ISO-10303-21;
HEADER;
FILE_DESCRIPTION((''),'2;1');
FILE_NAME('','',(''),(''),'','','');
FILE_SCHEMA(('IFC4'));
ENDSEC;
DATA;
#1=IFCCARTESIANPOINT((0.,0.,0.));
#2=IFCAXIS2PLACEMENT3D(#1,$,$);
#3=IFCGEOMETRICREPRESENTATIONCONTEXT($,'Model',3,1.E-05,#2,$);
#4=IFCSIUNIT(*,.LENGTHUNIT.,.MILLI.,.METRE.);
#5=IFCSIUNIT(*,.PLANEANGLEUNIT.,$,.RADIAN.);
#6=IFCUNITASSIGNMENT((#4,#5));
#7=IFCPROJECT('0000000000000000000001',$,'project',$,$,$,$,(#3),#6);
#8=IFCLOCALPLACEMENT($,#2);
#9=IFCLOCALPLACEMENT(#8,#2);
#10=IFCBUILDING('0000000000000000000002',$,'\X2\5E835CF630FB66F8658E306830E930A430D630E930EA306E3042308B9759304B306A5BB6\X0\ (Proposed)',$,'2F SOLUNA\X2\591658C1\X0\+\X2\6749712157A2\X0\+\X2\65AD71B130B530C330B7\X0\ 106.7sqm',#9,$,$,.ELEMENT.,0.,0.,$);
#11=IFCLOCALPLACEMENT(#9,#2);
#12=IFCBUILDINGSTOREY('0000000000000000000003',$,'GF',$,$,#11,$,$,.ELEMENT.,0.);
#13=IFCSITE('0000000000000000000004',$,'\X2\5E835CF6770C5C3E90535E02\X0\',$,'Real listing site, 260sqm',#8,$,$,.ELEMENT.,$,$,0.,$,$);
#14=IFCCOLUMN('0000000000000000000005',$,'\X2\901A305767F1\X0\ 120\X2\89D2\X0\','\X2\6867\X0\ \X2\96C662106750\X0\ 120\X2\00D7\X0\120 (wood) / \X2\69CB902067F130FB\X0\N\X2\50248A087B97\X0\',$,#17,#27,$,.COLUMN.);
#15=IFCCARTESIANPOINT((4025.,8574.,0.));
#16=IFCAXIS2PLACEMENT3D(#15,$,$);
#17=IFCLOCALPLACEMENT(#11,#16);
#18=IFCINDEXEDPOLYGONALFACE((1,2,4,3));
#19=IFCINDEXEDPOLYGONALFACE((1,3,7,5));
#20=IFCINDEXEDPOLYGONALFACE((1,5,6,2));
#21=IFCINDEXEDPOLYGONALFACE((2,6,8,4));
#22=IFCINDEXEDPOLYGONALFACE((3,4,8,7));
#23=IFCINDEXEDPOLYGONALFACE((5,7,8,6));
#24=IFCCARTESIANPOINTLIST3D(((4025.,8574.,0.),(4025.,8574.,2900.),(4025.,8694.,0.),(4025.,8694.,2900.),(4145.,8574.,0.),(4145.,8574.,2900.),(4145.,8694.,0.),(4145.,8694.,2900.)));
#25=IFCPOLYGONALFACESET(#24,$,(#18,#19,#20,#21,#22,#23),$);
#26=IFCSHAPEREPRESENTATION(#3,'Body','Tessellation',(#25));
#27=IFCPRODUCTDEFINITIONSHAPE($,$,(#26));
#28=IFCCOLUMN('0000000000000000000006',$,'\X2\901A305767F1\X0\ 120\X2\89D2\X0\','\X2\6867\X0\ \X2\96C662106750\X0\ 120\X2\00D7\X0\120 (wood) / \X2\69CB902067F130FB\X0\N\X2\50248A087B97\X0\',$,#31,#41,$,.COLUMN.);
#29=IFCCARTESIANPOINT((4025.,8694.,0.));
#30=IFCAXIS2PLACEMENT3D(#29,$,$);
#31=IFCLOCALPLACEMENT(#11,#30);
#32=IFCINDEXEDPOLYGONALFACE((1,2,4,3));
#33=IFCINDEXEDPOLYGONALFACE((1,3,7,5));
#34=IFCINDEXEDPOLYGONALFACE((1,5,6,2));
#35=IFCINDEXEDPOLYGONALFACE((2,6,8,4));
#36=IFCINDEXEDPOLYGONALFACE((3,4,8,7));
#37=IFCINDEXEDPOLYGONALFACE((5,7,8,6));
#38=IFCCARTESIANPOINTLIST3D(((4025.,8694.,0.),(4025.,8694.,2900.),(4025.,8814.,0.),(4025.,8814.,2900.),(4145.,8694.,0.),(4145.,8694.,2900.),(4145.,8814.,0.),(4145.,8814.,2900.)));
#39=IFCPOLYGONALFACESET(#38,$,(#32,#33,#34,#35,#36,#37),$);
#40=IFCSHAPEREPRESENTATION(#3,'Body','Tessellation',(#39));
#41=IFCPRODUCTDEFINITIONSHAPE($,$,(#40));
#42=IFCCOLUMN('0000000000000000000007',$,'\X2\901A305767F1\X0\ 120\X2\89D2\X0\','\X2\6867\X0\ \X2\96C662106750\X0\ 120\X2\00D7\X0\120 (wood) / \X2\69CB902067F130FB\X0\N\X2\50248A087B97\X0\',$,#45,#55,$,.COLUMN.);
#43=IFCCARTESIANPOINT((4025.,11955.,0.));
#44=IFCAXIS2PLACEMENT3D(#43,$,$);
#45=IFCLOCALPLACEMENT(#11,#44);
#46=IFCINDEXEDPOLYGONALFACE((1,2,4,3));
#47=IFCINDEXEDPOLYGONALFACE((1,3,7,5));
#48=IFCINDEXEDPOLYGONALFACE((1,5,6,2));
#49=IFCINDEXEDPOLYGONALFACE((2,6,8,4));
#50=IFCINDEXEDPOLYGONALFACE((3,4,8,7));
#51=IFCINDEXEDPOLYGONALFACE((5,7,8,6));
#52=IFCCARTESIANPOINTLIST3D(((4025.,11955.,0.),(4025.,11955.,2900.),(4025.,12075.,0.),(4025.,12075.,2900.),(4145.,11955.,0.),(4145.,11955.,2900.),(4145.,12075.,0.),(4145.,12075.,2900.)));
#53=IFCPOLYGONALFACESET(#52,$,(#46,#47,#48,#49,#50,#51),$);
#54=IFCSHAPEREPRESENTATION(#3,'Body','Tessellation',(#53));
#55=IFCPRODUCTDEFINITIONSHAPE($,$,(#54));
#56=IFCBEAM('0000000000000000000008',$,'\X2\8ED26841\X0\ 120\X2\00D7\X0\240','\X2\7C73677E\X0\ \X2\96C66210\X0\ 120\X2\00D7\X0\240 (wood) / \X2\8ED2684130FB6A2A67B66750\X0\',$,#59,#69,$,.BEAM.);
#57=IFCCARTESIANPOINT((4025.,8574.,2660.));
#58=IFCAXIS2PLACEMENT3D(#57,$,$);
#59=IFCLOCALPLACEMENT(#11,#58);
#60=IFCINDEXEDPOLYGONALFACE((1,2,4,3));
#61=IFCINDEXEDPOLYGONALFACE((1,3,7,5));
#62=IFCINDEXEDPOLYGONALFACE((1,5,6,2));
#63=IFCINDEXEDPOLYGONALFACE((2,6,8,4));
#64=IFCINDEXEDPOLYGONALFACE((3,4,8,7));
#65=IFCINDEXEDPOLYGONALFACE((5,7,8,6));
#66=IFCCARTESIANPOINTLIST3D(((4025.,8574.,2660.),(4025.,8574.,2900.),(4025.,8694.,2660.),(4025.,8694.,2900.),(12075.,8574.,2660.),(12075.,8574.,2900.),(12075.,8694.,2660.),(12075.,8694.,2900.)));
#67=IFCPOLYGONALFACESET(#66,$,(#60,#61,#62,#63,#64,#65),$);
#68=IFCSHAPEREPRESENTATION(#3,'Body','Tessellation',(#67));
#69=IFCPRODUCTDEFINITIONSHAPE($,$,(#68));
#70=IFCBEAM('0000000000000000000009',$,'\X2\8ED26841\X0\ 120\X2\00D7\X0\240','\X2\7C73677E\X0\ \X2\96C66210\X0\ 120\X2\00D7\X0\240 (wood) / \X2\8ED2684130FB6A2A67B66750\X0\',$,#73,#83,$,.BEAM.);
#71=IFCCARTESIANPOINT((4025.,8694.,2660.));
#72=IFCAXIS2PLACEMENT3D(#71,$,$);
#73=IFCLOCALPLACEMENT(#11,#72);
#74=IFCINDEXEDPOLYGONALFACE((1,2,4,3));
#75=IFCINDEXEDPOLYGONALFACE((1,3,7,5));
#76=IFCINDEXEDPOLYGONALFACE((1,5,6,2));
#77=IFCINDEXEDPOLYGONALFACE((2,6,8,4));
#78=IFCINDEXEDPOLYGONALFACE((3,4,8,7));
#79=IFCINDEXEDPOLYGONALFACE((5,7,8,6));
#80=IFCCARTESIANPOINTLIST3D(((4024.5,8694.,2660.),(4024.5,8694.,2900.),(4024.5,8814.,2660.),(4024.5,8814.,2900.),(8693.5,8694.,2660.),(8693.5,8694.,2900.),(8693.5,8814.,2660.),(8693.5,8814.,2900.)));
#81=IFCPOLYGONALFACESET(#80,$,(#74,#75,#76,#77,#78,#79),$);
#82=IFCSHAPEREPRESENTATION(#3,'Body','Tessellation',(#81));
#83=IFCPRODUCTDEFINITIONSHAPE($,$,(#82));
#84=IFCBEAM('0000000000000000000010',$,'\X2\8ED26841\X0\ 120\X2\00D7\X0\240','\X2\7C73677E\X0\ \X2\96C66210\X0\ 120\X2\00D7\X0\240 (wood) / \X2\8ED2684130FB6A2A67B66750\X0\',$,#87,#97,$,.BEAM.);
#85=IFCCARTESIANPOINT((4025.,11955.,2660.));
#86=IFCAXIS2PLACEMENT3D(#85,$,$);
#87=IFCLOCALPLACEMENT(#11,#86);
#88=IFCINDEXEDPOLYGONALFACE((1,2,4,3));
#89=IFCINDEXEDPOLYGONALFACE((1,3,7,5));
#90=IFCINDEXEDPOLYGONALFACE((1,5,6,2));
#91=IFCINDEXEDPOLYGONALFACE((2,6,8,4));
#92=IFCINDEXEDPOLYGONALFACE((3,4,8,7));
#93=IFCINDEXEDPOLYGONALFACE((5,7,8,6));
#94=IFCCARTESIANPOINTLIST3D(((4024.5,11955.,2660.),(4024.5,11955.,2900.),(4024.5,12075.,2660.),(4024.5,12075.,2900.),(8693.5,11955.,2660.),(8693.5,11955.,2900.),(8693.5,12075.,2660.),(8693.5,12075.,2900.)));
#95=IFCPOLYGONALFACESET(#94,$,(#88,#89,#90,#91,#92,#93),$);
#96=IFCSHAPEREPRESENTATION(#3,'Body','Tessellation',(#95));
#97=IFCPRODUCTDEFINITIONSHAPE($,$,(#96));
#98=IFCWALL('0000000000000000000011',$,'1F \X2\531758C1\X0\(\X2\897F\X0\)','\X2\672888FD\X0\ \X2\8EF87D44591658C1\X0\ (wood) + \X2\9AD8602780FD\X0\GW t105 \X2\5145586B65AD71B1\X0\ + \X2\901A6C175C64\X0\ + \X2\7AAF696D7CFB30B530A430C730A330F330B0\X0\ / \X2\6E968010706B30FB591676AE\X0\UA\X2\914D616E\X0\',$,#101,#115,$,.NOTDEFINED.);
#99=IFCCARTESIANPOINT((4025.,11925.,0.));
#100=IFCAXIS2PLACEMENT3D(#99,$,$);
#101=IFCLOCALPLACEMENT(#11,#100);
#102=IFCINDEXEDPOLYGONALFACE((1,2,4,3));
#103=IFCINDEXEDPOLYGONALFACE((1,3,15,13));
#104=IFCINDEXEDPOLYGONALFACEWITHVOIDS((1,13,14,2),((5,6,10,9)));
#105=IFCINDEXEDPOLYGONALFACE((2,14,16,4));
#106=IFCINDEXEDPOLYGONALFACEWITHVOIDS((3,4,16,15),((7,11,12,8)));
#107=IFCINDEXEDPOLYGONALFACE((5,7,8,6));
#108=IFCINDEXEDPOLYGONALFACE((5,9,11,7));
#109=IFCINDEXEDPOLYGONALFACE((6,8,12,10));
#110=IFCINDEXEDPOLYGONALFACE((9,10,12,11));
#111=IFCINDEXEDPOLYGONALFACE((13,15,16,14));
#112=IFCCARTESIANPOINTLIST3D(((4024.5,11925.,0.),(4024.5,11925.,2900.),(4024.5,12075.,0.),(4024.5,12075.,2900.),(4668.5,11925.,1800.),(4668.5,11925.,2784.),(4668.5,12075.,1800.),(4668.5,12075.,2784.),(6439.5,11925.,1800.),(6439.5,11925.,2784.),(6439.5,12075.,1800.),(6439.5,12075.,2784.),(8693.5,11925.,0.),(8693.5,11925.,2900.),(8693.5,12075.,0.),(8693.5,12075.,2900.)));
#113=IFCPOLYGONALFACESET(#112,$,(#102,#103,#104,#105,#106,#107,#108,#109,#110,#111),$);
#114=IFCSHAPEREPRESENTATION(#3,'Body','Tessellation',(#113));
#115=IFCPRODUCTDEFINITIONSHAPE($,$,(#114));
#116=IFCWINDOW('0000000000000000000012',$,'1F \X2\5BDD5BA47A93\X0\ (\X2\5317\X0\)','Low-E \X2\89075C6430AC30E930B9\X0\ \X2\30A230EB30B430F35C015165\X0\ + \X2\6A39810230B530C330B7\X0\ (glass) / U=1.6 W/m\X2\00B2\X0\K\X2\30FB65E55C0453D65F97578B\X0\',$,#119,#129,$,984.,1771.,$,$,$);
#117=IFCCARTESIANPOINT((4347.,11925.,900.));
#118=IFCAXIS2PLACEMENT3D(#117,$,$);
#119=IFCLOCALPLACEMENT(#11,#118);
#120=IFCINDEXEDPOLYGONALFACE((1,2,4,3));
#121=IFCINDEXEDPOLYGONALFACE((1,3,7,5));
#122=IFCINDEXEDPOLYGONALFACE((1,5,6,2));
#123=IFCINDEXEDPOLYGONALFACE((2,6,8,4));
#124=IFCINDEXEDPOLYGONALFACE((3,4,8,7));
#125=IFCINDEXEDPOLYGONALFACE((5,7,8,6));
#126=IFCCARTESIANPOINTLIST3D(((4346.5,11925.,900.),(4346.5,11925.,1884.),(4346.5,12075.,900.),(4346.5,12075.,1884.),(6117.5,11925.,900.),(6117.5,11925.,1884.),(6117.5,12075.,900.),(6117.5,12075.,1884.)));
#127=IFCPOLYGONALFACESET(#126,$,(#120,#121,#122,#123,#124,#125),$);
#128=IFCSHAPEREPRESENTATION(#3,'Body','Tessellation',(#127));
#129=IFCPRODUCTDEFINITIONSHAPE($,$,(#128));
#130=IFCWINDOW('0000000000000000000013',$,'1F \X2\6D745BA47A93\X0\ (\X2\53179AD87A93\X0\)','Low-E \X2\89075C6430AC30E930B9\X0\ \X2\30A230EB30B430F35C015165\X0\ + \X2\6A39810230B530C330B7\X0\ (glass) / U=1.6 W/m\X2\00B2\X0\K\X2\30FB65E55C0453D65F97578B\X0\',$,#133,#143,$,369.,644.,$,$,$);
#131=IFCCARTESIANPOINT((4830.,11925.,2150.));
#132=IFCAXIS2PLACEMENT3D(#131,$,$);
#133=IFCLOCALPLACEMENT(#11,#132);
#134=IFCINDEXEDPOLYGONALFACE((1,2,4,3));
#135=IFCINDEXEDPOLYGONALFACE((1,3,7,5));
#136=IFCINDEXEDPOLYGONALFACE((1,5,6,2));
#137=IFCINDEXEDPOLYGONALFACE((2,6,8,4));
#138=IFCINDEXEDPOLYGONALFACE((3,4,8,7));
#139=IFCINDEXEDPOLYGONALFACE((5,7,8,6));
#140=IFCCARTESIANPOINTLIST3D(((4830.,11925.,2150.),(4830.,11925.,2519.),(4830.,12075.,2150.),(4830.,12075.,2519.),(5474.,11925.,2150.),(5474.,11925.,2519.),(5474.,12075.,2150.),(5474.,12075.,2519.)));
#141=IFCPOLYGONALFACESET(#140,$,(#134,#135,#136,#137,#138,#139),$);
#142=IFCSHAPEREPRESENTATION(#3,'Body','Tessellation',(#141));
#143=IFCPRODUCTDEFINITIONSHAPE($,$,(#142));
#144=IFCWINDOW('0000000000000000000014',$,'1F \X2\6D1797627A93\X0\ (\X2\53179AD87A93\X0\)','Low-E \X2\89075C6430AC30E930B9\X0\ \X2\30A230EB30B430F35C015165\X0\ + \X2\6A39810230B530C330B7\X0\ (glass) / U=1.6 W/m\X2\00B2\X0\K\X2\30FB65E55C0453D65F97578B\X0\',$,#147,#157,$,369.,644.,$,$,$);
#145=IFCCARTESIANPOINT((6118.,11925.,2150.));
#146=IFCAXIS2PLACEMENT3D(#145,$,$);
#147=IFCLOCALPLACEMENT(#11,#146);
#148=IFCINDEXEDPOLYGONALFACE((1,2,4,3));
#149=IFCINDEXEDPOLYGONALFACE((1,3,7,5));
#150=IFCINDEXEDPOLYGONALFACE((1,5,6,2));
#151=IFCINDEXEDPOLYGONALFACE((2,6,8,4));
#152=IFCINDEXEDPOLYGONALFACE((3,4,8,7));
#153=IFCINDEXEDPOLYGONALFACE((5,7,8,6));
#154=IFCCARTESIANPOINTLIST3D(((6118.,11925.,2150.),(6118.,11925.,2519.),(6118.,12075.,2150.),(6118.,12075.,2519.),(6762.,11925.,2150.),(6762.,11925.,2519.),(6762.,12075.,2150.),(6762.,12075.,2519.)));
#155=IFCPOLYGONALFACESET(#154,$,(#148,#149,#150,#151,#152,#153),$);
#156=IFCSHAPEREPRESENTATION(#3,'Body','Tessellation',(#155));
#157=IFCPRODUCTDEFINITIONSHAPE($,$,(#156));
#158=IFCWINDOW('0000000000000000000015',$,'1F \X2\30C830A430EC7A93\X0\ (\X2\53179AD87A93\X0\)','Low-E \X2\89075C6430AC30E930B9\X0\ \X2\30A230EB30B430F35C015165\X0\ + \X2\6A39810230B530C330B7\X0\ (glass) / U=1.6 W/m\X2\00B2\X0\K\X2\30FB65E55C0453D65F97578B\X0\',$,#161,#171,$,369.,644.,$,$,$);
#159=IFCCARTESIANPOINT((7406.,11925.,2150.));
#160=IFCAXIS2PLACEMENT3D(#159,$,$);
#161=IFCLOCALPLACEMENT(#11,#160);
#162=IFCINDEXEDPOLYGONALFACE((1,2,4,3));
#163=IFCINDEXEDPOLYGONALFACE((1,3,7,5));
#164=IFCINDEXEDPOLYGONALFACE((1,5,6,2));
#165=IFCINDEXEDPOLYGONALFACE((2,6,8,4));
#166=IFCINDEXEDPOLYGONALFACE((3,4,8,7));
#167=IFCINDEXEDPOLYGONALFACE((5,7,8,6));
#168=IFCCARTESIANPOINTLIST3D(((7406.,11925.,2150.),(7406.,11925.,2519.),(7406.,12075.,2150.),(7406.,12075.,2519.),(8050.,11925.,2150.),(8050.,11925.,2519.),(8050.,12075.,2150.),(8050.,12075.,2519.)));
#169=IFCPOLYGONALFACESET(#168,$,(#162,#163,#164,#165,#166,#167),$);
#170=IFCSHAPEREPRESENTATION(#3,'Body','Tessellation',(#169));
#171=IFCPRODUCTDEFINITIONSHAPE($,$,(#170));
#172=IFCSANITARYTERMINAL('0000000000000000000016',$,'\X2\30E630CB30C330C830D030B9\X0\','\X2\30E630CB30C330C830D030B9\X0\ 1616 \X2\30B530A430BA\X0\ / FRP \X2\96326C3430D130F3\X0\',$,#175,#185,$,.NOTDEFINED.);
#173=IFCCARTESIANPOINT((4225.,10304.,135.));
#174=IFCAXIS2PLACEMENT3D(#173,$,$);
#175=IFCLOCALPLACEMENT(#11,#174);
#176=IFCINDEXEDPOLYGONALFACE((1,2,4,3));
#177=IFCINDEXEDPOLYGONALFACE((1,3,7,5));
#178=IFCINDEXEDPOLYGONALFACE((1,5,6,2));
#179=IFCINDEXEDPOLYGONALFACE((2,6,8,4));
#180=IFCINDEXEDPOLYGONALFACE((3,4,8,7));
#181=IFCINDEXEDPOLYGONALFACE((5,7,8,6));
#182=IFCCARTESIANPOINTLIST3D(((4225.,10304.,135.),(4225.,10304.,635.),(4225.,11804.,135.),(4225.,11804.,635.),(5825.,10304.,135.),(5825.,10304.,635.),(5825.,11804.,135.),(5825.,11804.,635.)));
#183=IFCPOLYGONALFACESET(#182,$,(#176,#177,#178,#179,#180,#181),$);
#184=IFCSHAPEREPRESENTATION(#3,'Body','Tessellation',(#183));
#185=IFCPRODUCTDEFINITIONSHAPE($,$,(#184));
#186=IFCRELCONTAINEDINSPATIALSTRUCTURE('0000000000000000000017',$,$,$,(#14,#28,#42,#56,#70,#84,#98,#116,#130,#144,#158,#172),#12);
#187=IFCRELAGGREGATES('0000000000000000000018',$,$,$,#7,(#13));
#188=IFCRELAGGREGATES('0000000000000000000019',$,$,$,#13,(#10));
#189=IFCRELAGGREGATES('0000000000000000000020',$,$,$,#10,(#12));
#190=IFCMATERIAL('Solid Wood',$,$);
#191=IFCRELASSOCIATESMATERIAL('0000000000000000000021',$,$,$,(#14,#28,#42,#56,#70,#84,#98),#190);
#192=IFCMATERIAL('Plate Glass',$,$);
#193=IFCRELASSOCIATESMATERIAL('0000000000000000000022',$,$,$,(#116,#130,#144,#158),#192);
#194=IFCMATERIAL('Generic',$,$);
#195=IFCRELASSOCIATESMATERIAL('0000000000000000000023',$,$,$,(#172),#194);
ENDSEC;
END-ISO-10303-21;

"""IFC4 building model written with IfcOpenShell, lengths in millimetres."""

from ifc_helpers import new_model, si_unit, frame, frame_2d, origin, place, context, project, spatial, rectangle, extrude, material, element, fill, save


model = new_model("IFC4")

# Units and contexts
model_context = context("Model", 3, precision=1e-05, world=origin())
ifc_project = project(units=[si_unit("LENGTHUNIT", "METRE", prefix="MILLI"), si_unit("PLANEANGLEUNIT", "RADIAN")], contexts=[model_context])

# Site, building, storey
site_placement = place(None, origin())
site = spatial("IfcSite", under=ifc_project, at=site_placement, Name="広島県尾道市", ObjectType="Real listing site, 260sqm", CompositionType="ELEMENT", RefElevation=0.0)
building_placement = place(site_placement, origin())
building = spatial("IfcBuilding", under=site, at=building_placement, Name="広島・書斎とライブラリのある静かな家 (Proposed)", ObjectType="2F SOLUNA外壁+杉無垢+断熱サッシ 106.7sqm", CompositionType="ELEMENT", ElevationOfRefHeight=0.0, ElevationOfTerrain=0.0)
storey_placement = place(building_placement, origin())
storey = spatial("IfcBuildingStorey", under=building, at=storey_placement, Name="GF", CompositionType="ELEMENT", Elevation=0.0)

# Columns
ifc_material_1 = material(Name="Solid Wood")
column_1_placement = place(storey_placement, frame((4025.0, 8574.0, 0.0)))
element("IfcColumn", 1, at=column_1_placement, inside=storey, material=ifc_material_1, Name="通し柱 120角", Description="桧 集成材 120×120 (wood) / 構造柱・N値計算", PredefinedType="COLUMN", context=model_context, shape_type="SweptSolid", body=[
    extrude(rectangle(XDim=120.0, YDim=120.0, at=frame_2d((60.0, 60.0))), frame((4025.0, 8574.0, 0.0)), (0.0, 0.0, 1.0), 2900.0),
])
column_2_placement = place(storey_placement, frame((4025.0, 8694.0, 0.0)))
element("IfcColumn", 2, at=column_2_placement, inside=storey, material=ifc_material_1, Name="通し柱 120角", Description="桧 集成材 120×120 (wood) / 構造柱・N値計算", PredefinedType="COLUMN", context=model_context, shape_type="SweptSolid", body=[
    extrude(rectangle(XDim=120.0, YDim=120.0, at=frame_2d((60.0, 60.0))), frame((4025.0, 8694.0, 0.0)), (0.0, 0.0, 1.0), 2900.0),
])
column_3_placement = place(storey_placement, frame((4025.0, 11955.0, 0.0)))
element("IfcColumn", 3, at=column_3_placement, inside=storey, material=ifc_material_1, Name="通し柱 120角", Description="桧 集成材 120×120 (wood) / 構造柱・N値計算", PredefinedType="COLUMN", context=model_context, shape_type="SweptSolid", body=[
    extrude(rectangle(XDim=120.0, YDim=120.0, at=frame_2d((60.0, 60.0))), frame((4025.0, 11955.0, 0.0)), (0.0, 0.0, 1.0), 2900.0),
])

# Beams
beam_1_placement = place(storey_placement, frame((4025.0, 8574.0, 2660.0)))
element("IfcBeam", 4, at=beam_1_placement, inside=storey, material=ifc_material_1, Name="軒桁 120×240", Description="米松 集成 120×240 (wood) / 軒桁・横架材", PredefinedType="BEAM", context=model_context, shape_type="SweptSolid", body=[
    extrude(rectangle(XDim=8050.0, YDim=120.0, at=frame_2d((4025.0, 60.0))), frame((4025.0, 8574.0, 2660.0)), (0.0, 0.0, 1.0), 240.0),
])
beam_2_placement = place(storey_placement, frame((4025.0, 8694.0, 2660.0)))
element("IfcBeam", 5, at=beam_2_placement, inside=storey, material=ifc_material_1, Name="軒桁 120×240", Description="米松 集成 120×240 (wood) / 軒桁・横架材", PredefinedType="BEAM", context=model_context, shape_type="SweptSolid", body=[
    extrude(rectangle(XDim=4669.0, YDim=120.0, at=frame_2d((2334.0, 60.0))), frame((4025.0, 8694.0, 2660.0)), (0.0, 0.0, 1.0), 240.0),
])
beam_3_placement = place(storey_placement, frame((4025.0, 11955.0, 2660.0)))
element("IfcBeam", 6, at=beam_3_placement, inside=storey, material=ifc_material_1, Name="軒桁 120×240", Description="米松 集成 120×240 (wood) / 軒桁・横架材", PredefinedType="BEAM", context=model_context, shape_type="SweptSolid", body=[
    extrude(rectangle(XDim=4669.0, YDim=120.0, at=frame_2d((2334.0, 60.0))), frame((4025.0, 11955.0, 2660.0)), (0.0, 0.0, 1.0), 240.0),
])

# Wall, openings, windows
wall_1_placement = place(storey_placement, frame((4025.0, 11925.0, 0.0)))
wall_1 = element("IfcWall", 7, at=wall_1_placement, inside=storey, material=ifc_material_1, Name="1F 北壁(西)", Description="木製 軸組外壁 (wood) + 高性能GW t105 充填断熱 + 通気層 + 窯業系サイディング / 準耐火・外皮UA配慮", PredefinedType="NOTDEFINED", context=model_context, shape_type="SweptSolid", body=[
    extrude(rectangle(XDim=4669.0, YDim=150.0, at=frame_2d((2334.0, 75.0))), frame((4025.0, 11925.0, 0.0)), (0.0, 0.0, 1.0), 2900.0),
])
opening_1_placement = place(storey_placement, frame((4347.0, 11925.0, 900.0)))
opening_1 = element("IfcOpeningElement", 8, at=opening_1_placement, cuts=wall_1, PredefinedType="NOTDEFINED", context=model_context, shape_type="SweptSolid", body=[
    extrude(rectangle(XDim=1771.0, YDim=150.0, at=frame_2d((885.0, 75.0))), frame((4347.0, 11925.0, 900.0)), (0.0, 0.0, 1.0), 984.0),
])
opening_2_placement = place(storey_placement, frame((4830.0, 11925.0, 2150.0)))
opening_2 = element("IfcOpeningElement", 9, at=opening_2_placement, cuts=wall_1, PredefinedType="NOTDEFINED", context=model_context, shape_type="SweptSolid", body=[
    extrude(rectangle(XDim=644.0, YDim=150.0, at=frame_2d((322.0, 75.0))), frame((4830.0, 11925.0, 2150.0)), (0.0, 0.0, 1.0), 369.0),
])
opening_3_placement = place(storey_placement, frame((6118.0, 11925.0, 2150.0)))
opening_3 = element("IfcOpeningElement", 10, at=opening_3_placement, cuts=wall_1, PredefinedType="NOTDEFINED", context=model_context, shape_type="SweptSolid", body=[
    extrude(rectangle(XDim=644.0, YDim=150.0, at=frame_2d((322.0, 75.0))), frame((6118.0, 11925.0, 2150.0)), (0.0, 0.0, 1.0), 369.0),
])
opening_4_placement = place(storey_placement, frame((7406.0, 11925.0, 2150.0)))
opening_4 = element("IfcOpeningElement", 11, at=opening_4_placement, cuts=wall_1, PredefinedType="NOTDEFINED", context=model_context, shape_type="SweptSolid", body=[
    extrude(rectangle(XDim=644.0, YDim=150.0, at=frame_2d((322.0, 75.0))), frame((7406.0, 11925.0, 2150.0)), (0.0, 0.0, 1.0), 369.0),
])
ifc_material_2 = material(Name="Plate Glass")
window_1_placement = place(storey_placement, frame((4347.0, 11925.0, 900.0)))
window_1 = element("IfcWindow", 12, at=window_1_placement, inside=storey, material=ifc_material_2, Name="1F 寝室窓 (北)", Description="Low-E 複層ガラス アルゴン封入 + 樹脂サッシ (glass) / U=1.6 W/m²K・日射取得型", OverallHeight=984.0, OverallWidth=1771.0, context=model_context, shape_type="SweptSolid", body=[
    extrude(rectangle(XDim=1771.0, YDim=150.0, at=frame_2d((885.0, 75.0))), frame((4347.0, 11925.0, 900.0)), (0.0, 0.0, 1.0), 984.0),
])
fill(opening_1, window_1)
window_2_placement = place(storey_placement, frame((4830.0, 11925.0, 2150.0)))
window_2 = element("IfcWindow", 13, at=window_2_placement, inside=storey, material=ifc_material_2, Name="1F 浴室窓 (北高窓)", Description="Low-E 複層ガラス アルゴン封入 + 樹脂サッシ (glass) / U=1.6 W/m²K・日射取得型", OverallHeight=369.0, OverallWidth=644.0, context=model_context, shape_type="SweptSolid", body=[
    extrude(rectangle(XDim=644.0, YDim=150.0, at=frame_2d((322.0, 75.0))), frame((4830.0, 11925.0, 2150.0)), (0.0, 0.0, 1.0), 369.0),
])
fill(opening_2, window_2)
window_3_placement = place(storey_placement, frame((6118.0, 11925.0, 2150.0)))
window_3 = element("IfcWindow", 14, at=window_3_placement, inside=storey, material=ifc_material_2, Name="1F 洗面窓 (北高窓)", Description="Low-E 複層ガラス アルゴン封入 + 樹脂サッシ (glass) / U=1.6 W/m²K・日射取得型", OverallHeight=369.0, OverallWidth=644.0, context=model_context, shape_type="SweptSolid", body=[
    extrude(rectangle(XDim=644.0, YDim=150.0, at=frame_2d((322.0, 75.0))), frame((6118.0, 11925.0, 2150.0)), (0.0, 0.0, 1.0), 369.0),
])
fill(opening_3, window_3)
window_4_placement = place(storey_placement, frame((7406.0, 11925.0, 2150.0)))
window_4 = element("IfcWindow", 15, at=window_4_placement, inside=storey, material=ifc_material_2, Name="1F トイレ窓 (北高窓)", Description="Low-E 複層ガラス アルゴン封入 + 樹脂サッシ (glass) / U=1.6 W/m²K・日射取得型", OverallHeight=369.0, OverallWidth=644.0, context=model_context, shape_type="SweptSolid", body=[
    extrude(rectangle(XDim=644.0, YDim=150.0, at=frame_2d((322.0, 75.0))), frame((7406.0, 11925.0, 2150.0)), (0.0, 0.0, 1.0), 369.0),
])
fill(opening_4, window_4)

# Shared definitions
ifc_material_3 = material(Name="Generic")

# Sanitary terminal
sanitary_terminal_placement = place(storey_placement, frame((4225.0, 10304.0, 135.0)))
element("IfcSanitaryTerminal", 16, at=sanitary_terminal_placement, inside=storey, material=ifc_material_3, Name="ユニットバス", Description="ユニットバス 1616 サイズ / FRP 防水パン", PredefinedType="NOTDEFINED", context=model_context, shape_type="SweptSolid", body=[
    extrude(rectangle(XDim=1600.0, YDim=1500.0, at=frame_2d((800.0, 750.0))), frame((4225.0, 10304.0, 135.0)), (0.0, 0.0, 1.0), 500.0),
])

save(model, "model.ifc")
